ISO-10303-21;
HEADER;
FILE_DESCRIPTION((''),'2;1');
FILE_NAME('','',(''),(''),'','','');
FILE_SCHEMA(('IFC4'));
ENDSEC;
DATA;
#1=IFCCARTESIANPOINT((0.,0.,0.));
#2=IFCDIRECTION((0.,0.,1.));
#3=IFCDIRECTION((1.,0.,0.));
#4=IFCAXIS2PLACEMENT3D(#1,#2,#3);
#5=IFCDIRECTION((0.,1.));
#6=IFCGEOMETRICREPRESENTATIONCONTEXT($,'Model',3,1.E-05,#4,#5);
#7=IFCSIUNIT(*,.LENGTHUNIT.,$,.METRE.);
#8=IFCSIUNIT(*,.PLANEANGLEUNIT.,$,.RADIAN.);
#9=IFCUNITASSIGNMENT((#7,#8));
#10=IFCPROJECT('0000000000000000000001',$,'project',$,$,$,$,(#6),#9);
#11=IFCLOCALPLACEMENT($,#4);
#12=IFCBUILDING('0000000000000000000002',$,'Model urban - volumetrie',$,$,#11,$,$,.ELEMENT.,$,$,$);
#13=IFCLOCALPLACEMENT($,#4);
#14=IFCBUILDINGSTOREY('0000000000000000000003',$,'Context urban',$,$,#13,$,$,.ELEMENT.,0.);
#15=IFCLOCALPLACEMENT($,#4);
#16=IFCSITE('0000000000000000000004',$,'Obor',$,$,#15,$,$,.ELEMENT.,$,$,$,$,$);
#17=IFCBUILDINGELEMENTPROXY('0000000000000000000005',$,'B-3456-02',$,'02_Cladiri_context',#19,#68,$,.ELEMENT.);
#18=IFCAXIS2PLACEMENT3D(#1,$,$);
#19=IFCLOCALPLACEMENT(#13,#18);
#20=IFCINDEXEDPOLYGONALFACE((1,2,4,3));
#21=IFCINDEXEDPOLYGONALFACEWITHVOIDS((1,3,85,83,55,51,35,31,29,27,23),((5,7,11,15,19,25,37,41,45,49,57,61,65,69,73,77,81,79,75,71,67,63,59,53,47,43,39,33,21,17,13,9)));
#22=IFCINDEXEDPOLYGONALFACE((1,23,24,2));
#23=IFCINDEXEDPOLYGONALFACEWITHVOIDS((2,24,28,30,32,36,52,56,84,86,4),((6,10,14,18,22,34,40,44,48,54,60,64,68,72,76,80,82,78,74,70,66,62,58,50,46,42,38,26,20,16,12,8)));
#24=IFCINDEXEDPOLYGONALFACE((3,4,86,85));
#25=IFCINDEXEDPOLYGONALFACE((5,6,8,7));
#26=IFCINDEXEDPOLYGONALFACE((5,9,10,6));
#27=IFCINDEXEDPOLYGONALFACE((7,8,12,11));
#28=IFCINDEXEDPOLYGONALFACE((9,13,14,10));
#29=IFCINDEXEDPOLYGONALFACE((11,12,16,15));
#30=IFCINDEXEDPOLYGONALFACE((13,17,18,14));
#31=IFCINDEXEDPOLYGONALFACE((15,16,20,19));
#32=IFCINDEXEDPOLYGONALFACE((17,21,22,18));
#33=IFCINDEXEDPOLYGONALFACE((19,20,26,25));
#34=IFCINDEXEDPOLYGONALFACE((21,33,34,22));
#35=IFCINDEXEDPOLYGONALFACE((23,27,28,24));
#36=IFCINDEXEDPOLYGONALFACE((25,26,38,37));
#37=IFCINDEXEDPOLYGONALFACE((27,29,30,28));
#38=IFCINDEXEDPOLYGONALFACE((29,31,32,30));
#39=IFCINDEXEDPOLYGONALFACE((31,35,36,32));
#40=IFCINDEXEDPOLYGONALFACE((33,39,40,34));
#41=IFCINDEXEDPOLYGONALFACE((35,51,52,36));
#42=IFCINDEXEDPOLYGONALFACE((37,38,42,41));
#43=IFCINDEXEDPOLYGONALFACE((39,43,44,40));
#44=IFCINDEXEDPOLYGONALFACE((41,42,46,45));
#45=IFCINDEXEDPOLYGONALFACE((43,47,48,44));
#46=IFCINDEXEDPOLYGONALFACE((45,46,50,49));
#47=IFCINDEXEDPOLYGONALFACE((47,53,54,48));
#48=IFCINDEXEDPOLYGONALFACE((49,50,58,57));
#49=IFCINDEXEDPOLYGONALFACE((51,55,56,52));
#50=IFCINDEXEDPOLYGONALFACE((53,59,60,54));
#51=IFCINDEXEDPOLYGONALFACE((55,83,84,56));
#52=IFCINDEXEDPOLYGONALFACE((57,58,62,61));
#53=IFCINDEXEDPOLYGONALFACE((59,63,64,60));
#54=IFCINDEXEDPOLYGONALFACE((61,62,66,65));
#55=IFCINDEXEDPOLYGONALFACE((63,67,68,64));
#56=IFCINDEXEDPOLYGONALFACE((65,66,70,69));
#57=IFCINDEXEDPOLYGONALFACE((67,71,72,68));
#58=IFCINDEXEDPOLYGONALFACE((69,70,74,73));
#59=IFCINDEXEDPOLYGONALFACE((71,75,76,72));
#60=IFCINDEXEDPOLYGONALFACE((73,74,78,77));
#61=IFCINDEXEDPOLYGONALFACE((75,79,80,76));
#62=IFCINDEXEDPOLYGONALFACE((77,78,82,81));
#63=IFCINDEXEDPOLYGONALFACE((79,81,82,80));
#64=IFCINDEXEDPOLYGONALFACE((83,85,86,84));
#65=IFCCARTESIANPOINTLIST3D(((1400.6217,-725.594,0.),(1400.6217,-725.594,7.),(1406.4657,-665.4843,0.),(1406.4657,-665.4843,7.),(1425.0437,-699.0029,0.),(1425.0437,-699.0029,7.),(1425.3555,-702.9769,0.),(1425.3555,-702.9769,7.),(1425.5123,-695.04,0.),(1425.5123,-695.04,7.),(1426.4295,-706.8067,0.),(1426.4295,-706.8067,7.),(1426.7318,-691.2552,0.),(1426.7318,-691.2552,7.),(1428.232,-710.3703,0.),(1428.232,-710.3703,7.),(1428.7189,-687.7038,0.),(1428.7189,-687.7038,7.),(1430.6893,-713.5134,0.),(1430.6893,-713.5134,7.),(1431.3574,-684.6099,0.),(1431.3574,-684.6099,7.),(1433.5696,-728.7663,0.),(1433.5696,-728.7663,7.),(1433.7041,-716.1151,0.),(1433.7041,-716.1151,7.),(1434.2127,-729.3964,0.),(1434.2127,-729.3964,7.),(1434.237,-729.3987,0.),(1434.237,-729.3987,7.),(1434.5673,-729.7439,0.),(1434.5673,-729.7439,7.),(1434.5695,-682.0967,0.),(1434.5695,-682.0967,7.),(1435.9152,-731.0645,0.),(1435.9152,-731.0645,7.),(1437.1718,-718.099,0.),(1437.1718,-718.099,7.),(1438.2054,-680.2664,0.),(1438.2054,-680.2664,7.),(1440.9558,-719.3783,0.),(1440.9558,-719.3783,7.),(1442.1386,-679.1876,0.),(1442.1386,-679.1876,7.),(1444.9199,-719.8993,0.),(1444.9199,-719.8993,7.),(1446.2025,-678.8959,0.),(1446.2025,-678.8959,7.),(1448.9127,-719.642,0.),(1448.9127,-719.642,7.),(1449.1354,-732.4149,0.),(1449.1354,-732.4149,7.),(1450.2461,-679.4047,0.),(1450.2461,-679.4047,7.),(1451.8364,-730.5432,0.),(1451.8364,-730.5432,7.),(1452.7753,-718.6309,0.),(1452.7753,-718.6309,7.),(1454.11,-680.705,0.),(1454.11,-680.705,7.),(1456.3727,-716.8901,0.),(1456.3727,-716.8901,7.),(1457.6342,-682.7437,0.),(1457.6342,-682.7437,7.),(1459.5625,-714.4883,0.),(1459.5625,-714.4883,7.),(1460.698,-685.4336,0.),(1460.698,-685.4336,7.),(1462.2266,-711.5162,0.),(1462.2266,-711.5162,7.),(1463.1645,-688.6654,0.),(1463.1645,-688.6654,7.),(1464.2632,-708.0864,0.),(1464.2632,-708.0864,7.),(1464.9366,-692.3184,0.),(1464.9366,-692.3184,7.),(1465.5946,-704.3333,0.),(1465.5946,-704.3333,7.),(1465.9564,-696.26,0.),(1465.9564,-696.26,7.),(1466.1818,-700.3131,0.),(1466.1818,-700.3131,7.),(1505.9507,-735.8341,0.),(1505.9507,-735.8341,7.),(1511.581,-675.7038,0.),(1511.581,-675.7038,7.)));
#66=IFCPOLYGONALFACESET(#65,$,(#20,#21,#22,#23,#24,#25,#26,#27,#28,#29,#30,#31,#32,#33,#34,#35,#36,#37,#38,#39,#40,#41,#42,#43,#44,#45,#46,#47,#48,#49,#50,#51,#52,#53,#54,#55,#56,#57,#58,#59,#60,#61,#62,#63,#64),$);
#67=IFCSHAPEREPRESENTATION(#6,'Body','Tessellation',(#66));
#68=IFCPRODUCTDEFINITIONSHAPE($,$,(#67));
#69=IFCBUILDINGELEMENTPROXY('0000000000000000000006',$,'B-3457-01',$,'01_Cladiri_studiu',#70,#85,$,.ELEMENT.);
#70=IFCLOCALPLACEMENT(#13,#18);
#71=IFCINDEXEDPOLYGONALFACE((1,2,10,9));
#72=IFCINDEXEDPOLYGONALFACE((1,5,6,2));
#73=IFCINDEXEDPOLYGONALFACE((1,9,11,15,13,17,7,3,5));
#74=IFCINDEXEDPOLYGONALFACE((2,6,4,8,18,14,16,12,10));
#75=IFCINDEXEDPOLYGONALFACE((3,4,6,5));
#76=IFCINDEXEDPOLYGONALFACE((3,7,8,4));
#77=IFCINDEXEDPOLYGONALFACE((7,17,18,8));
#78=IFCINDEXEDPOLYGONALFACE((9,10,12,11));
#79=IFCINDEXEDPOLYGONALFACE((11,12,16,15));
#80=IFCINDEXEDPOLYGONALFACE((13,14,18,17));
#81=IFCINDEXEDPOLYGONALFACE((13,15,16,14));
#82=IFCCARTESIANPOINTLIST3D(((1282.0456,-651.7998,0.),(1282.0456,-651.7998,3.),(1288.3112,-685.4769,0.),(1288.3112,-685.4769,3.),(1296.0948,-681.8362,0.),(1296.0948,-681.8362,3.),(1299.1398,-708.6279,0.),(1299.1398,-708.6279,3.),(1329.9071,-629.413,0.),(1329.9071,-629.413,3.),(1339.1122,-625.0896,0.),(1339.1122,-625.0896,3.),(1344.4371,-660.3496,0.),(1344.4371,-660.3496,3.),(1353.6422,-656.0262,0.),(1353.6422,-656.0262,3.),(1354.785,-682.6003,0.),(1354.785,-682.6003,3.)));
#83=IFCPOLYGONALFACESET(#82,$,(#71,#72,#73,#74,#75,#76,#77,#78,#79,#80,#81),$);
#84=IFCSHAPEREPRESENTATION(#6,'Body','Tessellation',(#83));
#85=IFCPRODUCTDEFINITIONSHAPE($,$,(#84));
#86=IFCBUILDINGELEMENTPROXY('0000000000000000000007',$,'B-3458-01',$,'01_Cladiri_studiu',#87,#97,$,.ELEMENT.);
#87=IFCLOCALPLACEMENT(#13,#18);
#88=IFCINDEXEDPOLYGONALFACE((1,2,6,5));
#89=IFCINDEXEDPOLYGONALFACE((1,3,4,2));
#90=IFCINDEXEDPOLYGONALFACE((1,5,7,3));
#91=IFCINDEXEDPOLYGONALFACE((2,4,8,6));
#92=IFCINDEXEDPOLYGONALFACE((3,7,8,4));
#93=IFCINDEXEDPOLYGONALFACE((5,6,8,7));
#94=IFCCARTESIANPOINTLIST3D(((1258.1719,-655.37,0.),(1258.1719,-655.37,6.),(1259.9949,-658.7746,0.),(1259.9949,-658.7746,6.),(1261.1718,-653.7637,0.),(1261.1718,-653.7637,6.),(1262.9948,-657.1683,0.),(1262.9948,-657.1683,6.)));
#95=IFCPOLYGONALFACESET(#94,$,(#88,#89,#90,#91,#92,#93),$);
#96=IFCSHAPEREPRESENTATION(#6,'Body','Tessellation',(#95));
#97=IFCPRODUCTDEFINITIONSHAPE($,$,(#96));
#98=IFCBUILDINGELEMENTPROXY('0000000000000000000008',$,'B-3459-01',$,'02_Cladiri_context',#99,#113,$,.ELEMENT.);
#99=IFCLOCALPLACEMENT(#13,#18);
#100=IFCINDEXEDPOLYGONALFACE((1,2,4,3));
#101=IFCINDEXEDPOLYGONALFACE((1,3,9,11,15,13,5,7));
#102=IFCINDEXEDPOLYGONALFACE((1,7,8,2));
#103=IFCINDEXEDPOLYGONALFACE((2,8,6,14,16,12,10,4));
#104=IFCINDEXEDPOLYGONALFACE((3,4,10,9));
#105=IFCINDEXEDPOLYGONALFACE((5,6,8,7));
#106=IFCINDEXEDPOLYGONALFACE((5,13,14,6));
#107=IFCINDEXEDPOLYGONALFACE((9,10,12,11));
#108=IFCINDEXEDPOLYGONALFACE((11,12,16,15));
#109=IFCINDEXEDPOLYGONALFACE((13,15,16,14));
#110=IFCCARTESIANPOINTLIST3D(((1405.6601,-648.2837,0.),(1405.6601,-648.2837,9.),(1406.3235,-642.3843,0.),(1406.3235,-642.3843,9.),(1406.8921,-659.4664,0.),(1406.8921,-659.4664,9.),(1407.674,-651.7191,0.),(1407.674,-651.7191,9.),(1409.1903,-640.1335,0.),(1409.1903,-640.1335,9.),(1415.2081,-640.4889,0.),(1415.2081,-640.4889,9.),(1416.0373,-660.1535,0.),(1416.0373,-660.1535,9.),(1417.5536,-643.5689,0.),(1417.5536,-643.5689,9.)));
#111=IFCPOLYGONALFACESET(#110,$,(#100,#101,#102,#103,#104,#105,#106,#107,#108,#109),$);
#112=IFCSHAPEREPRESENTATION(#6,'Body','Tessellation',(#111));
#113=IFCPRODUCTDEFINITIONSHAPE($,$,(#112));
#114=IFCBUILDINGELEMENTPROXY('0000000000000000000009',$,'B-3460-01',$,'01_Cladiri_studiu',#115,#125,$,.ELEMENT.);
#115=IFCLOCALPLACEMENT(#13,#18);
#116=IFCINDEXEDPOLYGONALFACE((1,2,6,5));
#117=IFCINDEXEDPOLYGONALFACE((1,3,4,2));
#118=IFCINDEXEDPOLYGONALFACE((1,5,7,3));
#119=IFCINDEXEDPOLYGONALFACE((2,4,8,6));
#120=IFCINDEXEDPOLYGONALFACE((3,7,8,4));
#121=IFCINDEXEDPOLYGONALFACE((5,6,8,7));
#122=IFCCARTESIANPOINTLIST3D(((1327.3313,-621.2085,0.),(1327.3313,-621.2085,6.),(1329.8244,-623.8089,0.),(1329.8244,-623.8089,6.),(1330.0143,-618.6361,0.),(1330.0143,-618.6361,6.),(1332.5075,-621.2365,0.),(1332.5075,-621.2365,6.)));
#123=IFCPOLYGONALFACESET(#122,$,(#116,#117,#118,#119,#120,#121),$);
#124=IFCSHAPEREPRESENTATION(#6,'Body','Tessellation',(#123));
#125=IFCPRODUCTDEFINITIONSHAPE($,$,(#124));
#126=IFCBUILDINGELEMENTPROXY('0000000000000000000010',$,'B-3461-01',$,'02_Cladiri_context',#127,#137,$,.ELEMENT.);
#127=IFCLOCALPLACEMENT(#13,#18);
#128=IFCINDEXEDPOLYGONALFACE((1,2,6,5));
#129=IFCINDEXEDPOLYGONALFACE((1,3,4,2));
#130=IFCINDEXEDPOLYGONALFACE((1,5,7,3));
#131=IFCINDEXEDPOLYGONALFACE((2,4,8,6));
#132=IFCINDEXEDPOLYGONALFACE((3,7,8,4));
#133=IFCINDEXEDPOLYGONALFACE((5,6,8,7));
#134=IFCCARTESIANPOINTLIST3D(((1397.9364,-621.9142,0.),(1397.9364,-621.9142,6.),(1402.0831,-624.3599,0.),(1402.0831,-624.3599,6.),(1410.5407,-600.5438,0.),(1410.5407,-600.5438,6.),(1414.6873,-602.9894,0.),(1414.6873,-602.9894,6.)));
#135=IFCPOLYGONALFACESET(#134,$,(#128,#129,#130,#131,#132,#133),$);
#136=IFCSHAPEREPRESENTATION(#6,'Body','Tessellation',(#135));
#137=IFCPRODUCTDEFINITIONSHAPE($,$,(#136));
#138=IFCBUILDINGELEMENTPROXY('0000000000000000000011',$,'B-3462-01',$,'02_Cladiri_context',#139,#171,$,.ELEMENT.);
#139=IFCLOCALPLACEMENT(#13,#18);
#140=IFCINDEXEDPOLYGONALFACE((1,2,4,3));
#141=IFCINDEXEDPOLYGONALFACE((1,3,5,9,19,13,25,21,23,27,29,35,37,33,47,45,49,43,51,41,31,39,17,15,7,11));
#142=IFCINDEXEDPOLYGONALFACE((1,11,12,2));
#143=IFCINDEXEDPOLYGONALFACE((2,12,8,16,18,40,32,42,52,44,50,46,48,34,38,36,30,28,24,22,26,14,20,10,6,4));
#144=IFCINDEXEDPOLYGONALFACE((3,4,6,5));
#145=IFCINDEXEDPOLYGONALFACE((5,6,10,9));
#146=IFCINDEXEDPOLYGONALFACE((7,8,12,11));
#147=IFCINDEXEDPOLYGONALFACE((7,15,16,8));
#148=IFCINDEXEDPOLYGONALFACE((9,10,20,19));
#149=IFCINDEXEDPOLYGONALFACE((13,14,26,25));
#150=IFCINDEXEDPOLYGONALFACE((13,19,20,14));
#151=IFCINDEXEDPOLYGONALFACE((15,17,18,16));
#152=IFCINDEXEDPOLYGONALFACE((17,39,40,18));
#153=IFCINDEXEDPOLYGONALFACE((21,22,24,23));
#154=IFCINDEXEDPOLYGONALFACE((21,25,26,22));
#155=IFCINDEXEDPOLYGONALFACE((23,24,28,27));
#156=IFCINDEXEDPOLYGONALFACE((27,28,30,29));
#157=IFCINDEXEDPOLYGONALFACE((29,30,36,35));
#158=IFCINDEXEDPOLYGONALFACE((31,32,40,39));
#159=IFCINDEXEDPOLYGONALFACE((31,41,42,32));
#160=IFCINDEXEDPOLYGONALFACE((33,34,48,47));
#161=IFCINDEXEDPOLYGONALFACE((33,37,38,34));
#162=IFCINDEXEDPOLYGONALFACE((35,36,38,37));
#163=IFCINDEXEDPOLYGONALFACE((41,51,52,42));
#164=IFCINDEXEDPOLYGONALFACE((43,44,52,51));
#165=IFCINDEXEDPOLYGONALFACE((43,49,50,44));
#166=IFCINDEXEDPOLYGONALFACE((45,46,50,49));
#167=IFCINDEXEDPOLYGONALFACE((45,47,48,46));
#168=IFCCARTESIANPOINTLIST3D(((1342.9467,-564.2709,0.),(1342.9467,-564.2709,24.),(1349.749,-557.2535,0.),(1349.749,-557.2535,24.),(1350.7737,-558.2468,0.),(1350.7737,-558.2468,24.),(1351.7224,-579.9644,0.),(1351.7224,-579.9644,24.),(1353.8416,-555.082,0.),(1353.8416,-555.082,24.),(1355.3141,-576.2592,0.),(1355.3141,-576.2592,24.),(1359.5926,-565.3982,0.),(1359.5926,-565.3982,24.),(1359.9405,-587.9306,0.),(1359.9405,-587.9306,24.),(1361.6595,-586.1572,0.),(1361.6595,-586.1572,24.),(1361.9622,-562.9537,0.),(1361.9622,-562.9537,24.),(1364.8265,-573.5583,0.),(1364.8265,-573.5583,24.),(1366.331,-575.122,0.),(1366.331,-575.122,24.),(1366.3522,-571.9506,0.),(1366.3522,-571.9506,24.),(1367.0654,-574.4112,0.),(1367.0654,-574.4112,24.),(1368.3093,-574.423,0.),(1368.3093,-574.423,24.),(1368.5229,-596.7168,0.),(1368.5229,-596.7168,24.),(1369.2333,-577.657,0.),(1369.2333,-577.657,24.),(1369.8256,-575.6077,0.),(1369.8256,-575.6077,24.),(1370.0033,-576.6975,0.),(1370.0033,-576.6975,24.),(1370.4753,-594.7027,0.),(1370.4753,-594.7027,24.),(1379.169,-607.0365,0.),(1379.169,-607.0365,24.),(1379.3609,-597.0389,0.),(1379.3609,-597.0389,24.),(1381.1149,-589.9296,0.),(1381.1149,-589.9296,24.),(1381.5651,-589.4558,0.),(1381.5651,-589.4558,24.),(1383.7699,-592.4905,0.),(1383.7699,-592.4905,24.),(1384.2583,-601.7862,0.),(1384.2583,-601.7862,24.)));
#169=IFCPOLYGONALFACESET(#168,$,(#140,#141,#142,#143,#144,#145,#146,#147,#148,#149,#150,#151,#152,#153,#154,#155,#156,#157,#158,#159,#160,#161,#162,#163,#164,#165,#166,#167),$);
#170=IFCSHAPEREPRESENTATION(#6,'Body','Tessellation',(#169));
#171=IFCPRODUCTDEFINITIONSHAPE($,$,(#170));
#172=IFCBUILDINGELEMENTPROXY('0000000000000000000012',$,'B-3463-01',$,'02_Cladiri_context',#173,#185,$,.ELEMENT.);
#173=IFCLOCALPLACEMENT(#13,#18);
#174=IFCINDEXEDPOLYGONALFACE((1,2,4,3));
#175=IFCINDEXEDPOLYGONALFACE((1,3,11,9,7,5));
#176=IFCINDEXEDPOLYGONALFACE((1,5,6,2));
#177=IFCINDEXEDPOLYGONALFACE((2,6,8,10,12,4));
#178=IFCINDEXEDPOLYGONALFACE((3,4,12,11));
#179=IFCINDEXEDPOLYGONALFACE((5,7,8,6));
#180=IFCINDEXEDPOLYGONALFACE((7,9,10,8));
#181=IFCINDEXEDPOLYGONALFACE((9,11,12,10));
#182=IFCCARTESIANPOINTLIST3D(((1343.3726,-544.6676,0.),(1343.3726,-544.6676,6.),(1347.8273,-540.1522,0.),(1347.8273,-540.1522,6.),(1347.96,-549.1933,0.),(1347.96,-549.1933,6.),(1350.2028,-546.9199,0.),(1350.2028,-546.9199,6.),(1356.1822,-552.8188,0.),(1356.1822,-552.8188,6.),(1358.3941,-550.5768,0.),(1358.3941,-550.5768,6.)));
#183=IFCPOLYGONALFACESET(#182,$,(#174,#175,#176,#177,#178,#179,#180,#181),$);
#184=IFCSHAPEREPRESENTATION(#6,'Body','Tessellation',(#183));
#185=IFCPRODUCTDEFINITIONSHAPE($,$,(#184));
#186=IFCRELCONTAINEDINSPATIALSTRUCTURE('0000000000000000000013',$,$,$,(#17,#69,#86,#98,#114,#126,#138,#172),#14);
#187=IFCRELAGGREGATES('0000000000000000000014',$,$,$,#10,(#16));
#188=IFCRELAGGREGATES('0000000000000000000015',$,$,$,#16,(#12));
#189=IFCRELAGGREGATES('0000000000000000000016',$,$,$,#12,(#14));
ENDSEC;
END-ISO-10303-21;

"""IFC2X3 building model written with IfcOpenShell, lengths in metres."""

from ifc_helpers import new_model, si_unit, direction, origin_with_axes, place, context, project, spatial, polyline, outline, extrude, element, save


model = new_model("IFC2X3")

# Units and contexts
model_context = context("Model", 3, precision=1e-05, world=origin_with_axes(), true_north=direction((0.0, 1.0)))
ifc_project = project(units=[si_unit("LENGTHUNIT", "METRE"), si_unit("PLANEANGLEUNIT", "RADIAN")], contexts=[model_context])

# Site, building, storey
site_placement = place(None, origin_with_axes())
site = spatial("IfcSite", under=ifc_project, at=site_placement, Name="Obor", CompositionType="ELEMENT")
building_placement = place(None, origin_with_axes())
building = spatial("IfcBuilding", under=site, at=building_placement, Name="Model urban - volumetrie", CompositionType="ELEMENT")
storey_placement = place(None, origin_with_axes())
storey = spatial("IfcBuildingStorey", under=building, at=storey_placement, Name="Context urban", CompositionType="ELEMENT", Elevation=0.0)

# Building element proxies
proxy_1_placement = place(None, origin_with_axes())
element("IfcBuildingElementProxy", 1, at=proxy_1_placement, inside=storey, Name="B-3456-02", ObjectType="02_Cladiri_context", CompositionType="ELEMENT", context=model_context, shape_type="SweptSolid", body=[
    extrude(outline(polyline([(1406.4657, -665.4843), (1400.6217, -725.594), (1433.5696, -728.7663), (1434.2127, -729.3964), (1434.237, -729.3987), (1434.5673, -729.7439), (1435.9152, -731.0645), (1449.1354, -732.4149), (1451.8364, -730.5432), (1505.9507, -735.8341), (1511.581, -675.7038), (1406.4657, -665.4843)]), holes=[polyline([(1430.6893, -713.5134), (1428.232, -710.3703), (1426.4295, -706.8067), (1425.3555, -702.9769), (1425.0437, -699.0029), (1425.5123, -695.04), (1426.7318, -691.2552), (1428.7189, -687.7038), (1431.3574, -684.6099), (1434.5695, -682.0967), (1438.2054, -680.2664), (1442.1386, -679.1876), (1446.2025, -678.8959), (1450.2461, -679.4047), (1454.11, -680.705), (1457.6342, -682.7437), (1460.698, -685.4336), (1463.1645, -688.6654), (1464.9366, -692.3184), (1465.9564, -696.26), (1466.1818, -700.3131), (1465.5946, -704.3333), (1464.2632, -708.0864), (1462.2266, -711.5162), (1459.5625, -714.4883), (1456.3727, -716.8901), (1452.7753, -718.6309), (1448.9127, -719.642), (1444.9199, -719.8993), (1440.9558, -719.3783), (1437.1718, -718.099), (1433.7041, -716.1151), (1430.6893, -713.5134)])]), origin_with_axes(), (0.0, 0.0, 1.0), 7.0),
])
proxy_2_placement = place(None, origin_with_axes())
element("IfcBuildingElementProxy", 2, at=proxy_2_placement, inside=storey, Name="B-3457-01", ObjectType="01_Cladiri_studiu", CompositionType="ELEMENT", context=model_context, shape_type="SweptSolid", body=[
    extrude(outline(polyline([(1296.0948, -681.8362), (1288.3112, -685.4769), (1299.1398, -708.6279), (1354.785, -682.6003), (1344.4371, -660.3496), (1353.6422, -656.0262), (1339.1122, -625.0896), (1329.9071, -629.413), (1282.0456, -651.7998), (1296.0948, -681.8362)])), origin_with_axes(), (0.0, 0.0, 1.0), 3.0),
])
proxy_3_placement = place(None, origin_with_axes())
element("IfcBuildingElementProxy", 3, at=proxy_3_placement, inside=storey, Name="B-3458-01", ObjectType="01_Cladiri_studiu", CompositionType="ELEMENT", context=model_context, shape_type="SweptSolid", body=[
    extrude(outline(polyline([(1262.9948, -657.1683), (1261.1718, -653.7637), (1258.1719, -655.37), (1259.9949, -658.7746), (1262.9948, -657.1683)])), origin_with_axes(), (0.0, 0.0, 1.0), 6.0),
])
proxy_4_placement = place(None, origin_with_axes())
element("IfcBuildingElementProxy", 4, at=proxy_4_placement, inside=storey, Name="B-3459-01", ObjectType="02_Cladiri_context", CompositionType="ELEMENT", context=model_context, shape_type="SweptSolid", body=[
    extrude(outline(polyline([(1415.2081, -640.4889), (1409.1903, -640.1335), (1406.3235, -642.3843), (1405.6601, -648.2837), (1407.674, -651.7191), (1406.8921, -659.4664), (1416.0373, -660.1535), (1417.5536, -643.5689), (1415.2081, -640.4889)])), origin_with_axes(), (0.0, 0.0, 1.0), 9.0),
])
proxy_5_placement = place(None, origin_with_axes())
element("IfcBuildingElementProxy", 5, at=proxy_5_placement, inside=storey, Name="B-3460-01", ObjectType="01_Cladiri_studiu", CompositionType="ELEMENT", context=model_context, shape_type="SweptSolid", body=[
    extrude(outline(polyline([(1327.3313, -621.2085), (1329.8244, -623.8089), (1332.5075, -621.2365), (1330.0143, -618.6361), (1327.3313, -621.2085)])), origin_with_axes(), (0.0, 0.0, 1.0), 6.0),
])
proxy_6_placement = place(None, origin_with_axes())
element("IfcBuildingElementProxy", 6, at=proxy_6_placement, inside=storey, Name="B-3461-01", ObjectType="02_Cladiri_context", CompositionType="ELEMENT", context=model_context, shape_type="SweptSolid", body=[
    extrude(outline(polyline([(1402.0831, -624.3599), (1414.6873, -602.9894), (1410.5407, -600.5438), (1397.9364, -621.9142), (1402.0831, -624.3599)])), origin_with_axes(), (0.0, 0.0, 1.0), 6.0),
])
proxy_7_placement = place(None, origin_with_axes())
element("IfcBuildingElementProxy", 7, at=proxy_7_placement, inside=storey, Name="B-3462-01", ObjectType="02_Cladiri_context", CompositionType="ELEMENT", context=model_context, shape_type="SweptSolid", body=[
    extrude(outline(polyline([(1381.5651, -589.4558), (1369.2333, -577.657), (1370.0033, -576.6975), (1369.8256, -575.6077), (1368.3093, -574.423), (1367.0654, -574.4112), (1366.331, -575.122), (1364.8265, -573.5583), (1366.3522, -571.9506), (1359.5926, -565.3982), (1361.9622, -562.9537), (1353.8416, -555.082), (1350.7737, -558.2468), (1349.749, -557.2535), (1342.9467, -564.2709), (1355.3141, -576.2592), (1351.7224, -579.9644), (1359.9405, -587.9306), (1361.6595, -586.1572), (1370.4753, -594.7027), (1368.5229, -596.7168), (1379.169, -607.0365), (1384.2583, -601.7862), (1379.3609, -597.0389), (1383.7699, -592.4905), (1381.1149, -589.9296), (1381.5651, -589.4558)])), origin_with_axes(), (0.0, 0.0, 1.0), 24.0),
])
proxy_8_placement = place(None, origin_with_axes())
element("IfcBuildingElementProxy", 8, at=proxy_8_placement, inside=storey, Name="B-3463-01", ObjectType="02_Cladiri_context", CompositionType="ELEMENT", context=model_context, shape_type="SweptSolid", body=[
    extrude(outline(polyline([(1350.2028, -546.9199), (1356.1822, -552.8188), (1358.3941, -550.5768), (1347.8273, -540.1522), (1343.3726, -544.6676), (1347.96, -549.1933), (1350.2028, -546.9199)])), origin_with_axes(), (0.0, 0.0, 1.0), 6.0),
])

save(model, "model.ifc")
